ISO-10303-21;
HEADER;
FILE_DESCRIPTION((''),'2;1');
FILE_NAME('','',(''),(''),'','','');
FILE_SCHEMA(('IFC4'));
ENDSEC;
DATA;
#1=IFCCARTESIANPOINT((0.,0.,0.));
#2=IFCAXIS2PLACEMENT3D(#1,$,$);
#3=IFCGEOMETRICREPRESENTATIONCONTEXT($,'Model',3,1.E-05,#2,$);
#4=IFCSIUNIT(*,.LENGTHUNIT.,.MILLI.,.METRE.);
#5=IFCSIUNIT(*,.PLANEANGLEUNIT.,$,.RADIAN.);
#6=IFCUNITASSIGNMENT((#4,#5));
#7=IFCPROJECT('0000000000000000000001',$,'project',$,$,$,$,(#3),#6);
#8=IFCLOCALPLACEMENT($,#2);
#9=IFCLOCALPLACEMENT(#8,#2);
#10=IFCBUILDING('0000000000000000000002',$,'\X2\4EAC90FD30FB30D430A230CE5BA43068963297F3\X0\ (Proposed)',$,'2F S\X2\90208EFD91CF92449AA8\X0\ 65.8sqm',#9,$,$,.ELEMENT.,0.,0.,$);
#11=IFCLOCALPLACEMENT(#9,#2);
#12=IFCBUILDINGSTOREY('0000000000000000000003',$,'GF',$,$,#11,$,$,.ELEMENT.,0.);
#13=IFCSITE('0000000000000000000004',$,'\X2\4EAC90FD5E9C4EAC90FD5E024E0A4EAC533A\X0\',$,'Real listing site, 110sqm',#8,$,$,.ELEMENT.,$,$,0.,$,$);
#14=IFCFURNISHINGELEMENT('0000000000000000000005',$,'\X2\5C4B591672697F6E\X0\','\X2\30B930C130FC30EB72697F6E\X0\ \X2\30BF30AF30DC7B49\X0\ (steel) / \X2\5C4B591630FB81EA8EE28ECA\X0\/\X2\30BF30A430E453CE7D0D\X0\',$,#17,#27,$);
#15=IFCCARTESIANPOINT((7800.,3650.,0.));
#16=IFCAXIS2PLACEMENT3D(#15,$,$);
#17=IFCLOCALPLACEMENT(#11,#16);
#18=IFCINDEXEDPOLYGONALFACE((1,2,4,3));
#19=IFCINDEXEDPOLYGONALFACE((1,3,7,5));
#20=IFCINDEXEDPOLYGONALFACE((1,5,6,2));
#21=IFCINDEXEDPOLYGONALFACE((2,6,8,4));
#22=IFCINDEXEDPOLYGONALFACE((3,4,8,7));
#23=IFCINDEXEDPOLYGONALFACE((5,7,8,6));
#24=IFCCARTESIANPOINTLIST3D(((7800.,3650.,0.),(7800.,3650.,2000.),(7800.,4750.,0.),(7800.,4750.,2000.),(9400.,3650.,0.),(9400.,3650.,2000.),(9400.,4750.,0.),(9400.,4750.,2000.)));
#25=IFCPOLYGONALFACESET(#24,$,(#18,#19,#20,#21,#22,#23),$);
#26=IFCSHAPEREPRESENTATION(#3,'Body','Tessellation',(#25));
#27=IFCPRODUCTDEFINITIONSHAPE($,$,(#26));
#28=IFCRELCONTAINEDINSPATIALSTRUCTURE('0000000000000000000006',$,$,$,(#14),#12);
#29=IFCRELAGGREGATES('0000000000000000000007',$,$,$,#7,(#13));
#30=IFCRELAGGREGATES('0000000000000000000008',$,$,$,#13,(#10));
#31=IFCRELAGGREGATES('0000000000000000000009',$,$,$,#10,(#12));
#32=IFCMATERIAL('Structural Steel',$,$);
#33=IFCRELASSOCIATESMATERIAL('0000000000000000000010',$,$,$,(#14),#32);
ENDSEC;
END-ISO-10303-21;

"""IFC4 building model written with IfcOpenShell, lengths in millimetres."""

from ifc_helpers import new_model, si_unit, frame, frame_2d, origin, place, context, project, spatial, rectangle, extrude, material, element, save


model = new_model("IFC4")

# Units and contexts
model_context = context("Model", 3, precision=1e-05, world=origin())
ifc_project = project(units=[si_unit("LENGTHUNIT", "METRE", prefix="MILLI"), si_unit("PLANEANGLEUNIT", "RADIAN")], contexts=[model_context])

# Site, building, storey
site_placement = place(None, origin())
site = spatial("IfcSite", under=ifc_project, at=site_placement, Name="京都府京都市上京区", ObjectType="Real listing site, 110sqm", CompositionType="ELEMENT", RefElevation=0.0)
building_placement = place(site_placement, origin())
building = spatial("IfcBuilding", under=site, at=building_placement, Name="京都・ピアノ室と防音 (Proposed)", ObjectType="2F S造軽量鉄骨 65.8sqm", CompositionType="ELEMENT", ElevationOfRefHeight=0.0, ElevationOfTerrain=0.0)
storey_placement = place(building_placement, origin())
storey = spatial("IfcBuildingStorey", under=building, at=storey_placement, Name="GF", CompositionType="ELEMENT", Elevation=0.0)

# Shared definitions
ifc_material_1 = material(Name="Structural Steel")

# Furnishing element
furnishing_1_placement = place(storey_placement, frame((7800.0, 3650.0, 0.0)))
element("IfcFurnishingElement", 1, at=furnishing_1_placement, inside=storey, material=ifc_material_1, Name="屋外物置", Description="スチール物置 タクボ等 (steel) / 屋外・自転車/タイヤ収納", context=model_context, shape_type="SweptSolid", body=[
    extrude(rectangle(XDim=1600.0, YDim=1100.0, at=frame_2d((800.0, 550.0))), frame((7800.0, 3650.0, 0.0)), (0.0, 0.0, 1.0), 2000.0),
])

save(model, "model.ifc")
